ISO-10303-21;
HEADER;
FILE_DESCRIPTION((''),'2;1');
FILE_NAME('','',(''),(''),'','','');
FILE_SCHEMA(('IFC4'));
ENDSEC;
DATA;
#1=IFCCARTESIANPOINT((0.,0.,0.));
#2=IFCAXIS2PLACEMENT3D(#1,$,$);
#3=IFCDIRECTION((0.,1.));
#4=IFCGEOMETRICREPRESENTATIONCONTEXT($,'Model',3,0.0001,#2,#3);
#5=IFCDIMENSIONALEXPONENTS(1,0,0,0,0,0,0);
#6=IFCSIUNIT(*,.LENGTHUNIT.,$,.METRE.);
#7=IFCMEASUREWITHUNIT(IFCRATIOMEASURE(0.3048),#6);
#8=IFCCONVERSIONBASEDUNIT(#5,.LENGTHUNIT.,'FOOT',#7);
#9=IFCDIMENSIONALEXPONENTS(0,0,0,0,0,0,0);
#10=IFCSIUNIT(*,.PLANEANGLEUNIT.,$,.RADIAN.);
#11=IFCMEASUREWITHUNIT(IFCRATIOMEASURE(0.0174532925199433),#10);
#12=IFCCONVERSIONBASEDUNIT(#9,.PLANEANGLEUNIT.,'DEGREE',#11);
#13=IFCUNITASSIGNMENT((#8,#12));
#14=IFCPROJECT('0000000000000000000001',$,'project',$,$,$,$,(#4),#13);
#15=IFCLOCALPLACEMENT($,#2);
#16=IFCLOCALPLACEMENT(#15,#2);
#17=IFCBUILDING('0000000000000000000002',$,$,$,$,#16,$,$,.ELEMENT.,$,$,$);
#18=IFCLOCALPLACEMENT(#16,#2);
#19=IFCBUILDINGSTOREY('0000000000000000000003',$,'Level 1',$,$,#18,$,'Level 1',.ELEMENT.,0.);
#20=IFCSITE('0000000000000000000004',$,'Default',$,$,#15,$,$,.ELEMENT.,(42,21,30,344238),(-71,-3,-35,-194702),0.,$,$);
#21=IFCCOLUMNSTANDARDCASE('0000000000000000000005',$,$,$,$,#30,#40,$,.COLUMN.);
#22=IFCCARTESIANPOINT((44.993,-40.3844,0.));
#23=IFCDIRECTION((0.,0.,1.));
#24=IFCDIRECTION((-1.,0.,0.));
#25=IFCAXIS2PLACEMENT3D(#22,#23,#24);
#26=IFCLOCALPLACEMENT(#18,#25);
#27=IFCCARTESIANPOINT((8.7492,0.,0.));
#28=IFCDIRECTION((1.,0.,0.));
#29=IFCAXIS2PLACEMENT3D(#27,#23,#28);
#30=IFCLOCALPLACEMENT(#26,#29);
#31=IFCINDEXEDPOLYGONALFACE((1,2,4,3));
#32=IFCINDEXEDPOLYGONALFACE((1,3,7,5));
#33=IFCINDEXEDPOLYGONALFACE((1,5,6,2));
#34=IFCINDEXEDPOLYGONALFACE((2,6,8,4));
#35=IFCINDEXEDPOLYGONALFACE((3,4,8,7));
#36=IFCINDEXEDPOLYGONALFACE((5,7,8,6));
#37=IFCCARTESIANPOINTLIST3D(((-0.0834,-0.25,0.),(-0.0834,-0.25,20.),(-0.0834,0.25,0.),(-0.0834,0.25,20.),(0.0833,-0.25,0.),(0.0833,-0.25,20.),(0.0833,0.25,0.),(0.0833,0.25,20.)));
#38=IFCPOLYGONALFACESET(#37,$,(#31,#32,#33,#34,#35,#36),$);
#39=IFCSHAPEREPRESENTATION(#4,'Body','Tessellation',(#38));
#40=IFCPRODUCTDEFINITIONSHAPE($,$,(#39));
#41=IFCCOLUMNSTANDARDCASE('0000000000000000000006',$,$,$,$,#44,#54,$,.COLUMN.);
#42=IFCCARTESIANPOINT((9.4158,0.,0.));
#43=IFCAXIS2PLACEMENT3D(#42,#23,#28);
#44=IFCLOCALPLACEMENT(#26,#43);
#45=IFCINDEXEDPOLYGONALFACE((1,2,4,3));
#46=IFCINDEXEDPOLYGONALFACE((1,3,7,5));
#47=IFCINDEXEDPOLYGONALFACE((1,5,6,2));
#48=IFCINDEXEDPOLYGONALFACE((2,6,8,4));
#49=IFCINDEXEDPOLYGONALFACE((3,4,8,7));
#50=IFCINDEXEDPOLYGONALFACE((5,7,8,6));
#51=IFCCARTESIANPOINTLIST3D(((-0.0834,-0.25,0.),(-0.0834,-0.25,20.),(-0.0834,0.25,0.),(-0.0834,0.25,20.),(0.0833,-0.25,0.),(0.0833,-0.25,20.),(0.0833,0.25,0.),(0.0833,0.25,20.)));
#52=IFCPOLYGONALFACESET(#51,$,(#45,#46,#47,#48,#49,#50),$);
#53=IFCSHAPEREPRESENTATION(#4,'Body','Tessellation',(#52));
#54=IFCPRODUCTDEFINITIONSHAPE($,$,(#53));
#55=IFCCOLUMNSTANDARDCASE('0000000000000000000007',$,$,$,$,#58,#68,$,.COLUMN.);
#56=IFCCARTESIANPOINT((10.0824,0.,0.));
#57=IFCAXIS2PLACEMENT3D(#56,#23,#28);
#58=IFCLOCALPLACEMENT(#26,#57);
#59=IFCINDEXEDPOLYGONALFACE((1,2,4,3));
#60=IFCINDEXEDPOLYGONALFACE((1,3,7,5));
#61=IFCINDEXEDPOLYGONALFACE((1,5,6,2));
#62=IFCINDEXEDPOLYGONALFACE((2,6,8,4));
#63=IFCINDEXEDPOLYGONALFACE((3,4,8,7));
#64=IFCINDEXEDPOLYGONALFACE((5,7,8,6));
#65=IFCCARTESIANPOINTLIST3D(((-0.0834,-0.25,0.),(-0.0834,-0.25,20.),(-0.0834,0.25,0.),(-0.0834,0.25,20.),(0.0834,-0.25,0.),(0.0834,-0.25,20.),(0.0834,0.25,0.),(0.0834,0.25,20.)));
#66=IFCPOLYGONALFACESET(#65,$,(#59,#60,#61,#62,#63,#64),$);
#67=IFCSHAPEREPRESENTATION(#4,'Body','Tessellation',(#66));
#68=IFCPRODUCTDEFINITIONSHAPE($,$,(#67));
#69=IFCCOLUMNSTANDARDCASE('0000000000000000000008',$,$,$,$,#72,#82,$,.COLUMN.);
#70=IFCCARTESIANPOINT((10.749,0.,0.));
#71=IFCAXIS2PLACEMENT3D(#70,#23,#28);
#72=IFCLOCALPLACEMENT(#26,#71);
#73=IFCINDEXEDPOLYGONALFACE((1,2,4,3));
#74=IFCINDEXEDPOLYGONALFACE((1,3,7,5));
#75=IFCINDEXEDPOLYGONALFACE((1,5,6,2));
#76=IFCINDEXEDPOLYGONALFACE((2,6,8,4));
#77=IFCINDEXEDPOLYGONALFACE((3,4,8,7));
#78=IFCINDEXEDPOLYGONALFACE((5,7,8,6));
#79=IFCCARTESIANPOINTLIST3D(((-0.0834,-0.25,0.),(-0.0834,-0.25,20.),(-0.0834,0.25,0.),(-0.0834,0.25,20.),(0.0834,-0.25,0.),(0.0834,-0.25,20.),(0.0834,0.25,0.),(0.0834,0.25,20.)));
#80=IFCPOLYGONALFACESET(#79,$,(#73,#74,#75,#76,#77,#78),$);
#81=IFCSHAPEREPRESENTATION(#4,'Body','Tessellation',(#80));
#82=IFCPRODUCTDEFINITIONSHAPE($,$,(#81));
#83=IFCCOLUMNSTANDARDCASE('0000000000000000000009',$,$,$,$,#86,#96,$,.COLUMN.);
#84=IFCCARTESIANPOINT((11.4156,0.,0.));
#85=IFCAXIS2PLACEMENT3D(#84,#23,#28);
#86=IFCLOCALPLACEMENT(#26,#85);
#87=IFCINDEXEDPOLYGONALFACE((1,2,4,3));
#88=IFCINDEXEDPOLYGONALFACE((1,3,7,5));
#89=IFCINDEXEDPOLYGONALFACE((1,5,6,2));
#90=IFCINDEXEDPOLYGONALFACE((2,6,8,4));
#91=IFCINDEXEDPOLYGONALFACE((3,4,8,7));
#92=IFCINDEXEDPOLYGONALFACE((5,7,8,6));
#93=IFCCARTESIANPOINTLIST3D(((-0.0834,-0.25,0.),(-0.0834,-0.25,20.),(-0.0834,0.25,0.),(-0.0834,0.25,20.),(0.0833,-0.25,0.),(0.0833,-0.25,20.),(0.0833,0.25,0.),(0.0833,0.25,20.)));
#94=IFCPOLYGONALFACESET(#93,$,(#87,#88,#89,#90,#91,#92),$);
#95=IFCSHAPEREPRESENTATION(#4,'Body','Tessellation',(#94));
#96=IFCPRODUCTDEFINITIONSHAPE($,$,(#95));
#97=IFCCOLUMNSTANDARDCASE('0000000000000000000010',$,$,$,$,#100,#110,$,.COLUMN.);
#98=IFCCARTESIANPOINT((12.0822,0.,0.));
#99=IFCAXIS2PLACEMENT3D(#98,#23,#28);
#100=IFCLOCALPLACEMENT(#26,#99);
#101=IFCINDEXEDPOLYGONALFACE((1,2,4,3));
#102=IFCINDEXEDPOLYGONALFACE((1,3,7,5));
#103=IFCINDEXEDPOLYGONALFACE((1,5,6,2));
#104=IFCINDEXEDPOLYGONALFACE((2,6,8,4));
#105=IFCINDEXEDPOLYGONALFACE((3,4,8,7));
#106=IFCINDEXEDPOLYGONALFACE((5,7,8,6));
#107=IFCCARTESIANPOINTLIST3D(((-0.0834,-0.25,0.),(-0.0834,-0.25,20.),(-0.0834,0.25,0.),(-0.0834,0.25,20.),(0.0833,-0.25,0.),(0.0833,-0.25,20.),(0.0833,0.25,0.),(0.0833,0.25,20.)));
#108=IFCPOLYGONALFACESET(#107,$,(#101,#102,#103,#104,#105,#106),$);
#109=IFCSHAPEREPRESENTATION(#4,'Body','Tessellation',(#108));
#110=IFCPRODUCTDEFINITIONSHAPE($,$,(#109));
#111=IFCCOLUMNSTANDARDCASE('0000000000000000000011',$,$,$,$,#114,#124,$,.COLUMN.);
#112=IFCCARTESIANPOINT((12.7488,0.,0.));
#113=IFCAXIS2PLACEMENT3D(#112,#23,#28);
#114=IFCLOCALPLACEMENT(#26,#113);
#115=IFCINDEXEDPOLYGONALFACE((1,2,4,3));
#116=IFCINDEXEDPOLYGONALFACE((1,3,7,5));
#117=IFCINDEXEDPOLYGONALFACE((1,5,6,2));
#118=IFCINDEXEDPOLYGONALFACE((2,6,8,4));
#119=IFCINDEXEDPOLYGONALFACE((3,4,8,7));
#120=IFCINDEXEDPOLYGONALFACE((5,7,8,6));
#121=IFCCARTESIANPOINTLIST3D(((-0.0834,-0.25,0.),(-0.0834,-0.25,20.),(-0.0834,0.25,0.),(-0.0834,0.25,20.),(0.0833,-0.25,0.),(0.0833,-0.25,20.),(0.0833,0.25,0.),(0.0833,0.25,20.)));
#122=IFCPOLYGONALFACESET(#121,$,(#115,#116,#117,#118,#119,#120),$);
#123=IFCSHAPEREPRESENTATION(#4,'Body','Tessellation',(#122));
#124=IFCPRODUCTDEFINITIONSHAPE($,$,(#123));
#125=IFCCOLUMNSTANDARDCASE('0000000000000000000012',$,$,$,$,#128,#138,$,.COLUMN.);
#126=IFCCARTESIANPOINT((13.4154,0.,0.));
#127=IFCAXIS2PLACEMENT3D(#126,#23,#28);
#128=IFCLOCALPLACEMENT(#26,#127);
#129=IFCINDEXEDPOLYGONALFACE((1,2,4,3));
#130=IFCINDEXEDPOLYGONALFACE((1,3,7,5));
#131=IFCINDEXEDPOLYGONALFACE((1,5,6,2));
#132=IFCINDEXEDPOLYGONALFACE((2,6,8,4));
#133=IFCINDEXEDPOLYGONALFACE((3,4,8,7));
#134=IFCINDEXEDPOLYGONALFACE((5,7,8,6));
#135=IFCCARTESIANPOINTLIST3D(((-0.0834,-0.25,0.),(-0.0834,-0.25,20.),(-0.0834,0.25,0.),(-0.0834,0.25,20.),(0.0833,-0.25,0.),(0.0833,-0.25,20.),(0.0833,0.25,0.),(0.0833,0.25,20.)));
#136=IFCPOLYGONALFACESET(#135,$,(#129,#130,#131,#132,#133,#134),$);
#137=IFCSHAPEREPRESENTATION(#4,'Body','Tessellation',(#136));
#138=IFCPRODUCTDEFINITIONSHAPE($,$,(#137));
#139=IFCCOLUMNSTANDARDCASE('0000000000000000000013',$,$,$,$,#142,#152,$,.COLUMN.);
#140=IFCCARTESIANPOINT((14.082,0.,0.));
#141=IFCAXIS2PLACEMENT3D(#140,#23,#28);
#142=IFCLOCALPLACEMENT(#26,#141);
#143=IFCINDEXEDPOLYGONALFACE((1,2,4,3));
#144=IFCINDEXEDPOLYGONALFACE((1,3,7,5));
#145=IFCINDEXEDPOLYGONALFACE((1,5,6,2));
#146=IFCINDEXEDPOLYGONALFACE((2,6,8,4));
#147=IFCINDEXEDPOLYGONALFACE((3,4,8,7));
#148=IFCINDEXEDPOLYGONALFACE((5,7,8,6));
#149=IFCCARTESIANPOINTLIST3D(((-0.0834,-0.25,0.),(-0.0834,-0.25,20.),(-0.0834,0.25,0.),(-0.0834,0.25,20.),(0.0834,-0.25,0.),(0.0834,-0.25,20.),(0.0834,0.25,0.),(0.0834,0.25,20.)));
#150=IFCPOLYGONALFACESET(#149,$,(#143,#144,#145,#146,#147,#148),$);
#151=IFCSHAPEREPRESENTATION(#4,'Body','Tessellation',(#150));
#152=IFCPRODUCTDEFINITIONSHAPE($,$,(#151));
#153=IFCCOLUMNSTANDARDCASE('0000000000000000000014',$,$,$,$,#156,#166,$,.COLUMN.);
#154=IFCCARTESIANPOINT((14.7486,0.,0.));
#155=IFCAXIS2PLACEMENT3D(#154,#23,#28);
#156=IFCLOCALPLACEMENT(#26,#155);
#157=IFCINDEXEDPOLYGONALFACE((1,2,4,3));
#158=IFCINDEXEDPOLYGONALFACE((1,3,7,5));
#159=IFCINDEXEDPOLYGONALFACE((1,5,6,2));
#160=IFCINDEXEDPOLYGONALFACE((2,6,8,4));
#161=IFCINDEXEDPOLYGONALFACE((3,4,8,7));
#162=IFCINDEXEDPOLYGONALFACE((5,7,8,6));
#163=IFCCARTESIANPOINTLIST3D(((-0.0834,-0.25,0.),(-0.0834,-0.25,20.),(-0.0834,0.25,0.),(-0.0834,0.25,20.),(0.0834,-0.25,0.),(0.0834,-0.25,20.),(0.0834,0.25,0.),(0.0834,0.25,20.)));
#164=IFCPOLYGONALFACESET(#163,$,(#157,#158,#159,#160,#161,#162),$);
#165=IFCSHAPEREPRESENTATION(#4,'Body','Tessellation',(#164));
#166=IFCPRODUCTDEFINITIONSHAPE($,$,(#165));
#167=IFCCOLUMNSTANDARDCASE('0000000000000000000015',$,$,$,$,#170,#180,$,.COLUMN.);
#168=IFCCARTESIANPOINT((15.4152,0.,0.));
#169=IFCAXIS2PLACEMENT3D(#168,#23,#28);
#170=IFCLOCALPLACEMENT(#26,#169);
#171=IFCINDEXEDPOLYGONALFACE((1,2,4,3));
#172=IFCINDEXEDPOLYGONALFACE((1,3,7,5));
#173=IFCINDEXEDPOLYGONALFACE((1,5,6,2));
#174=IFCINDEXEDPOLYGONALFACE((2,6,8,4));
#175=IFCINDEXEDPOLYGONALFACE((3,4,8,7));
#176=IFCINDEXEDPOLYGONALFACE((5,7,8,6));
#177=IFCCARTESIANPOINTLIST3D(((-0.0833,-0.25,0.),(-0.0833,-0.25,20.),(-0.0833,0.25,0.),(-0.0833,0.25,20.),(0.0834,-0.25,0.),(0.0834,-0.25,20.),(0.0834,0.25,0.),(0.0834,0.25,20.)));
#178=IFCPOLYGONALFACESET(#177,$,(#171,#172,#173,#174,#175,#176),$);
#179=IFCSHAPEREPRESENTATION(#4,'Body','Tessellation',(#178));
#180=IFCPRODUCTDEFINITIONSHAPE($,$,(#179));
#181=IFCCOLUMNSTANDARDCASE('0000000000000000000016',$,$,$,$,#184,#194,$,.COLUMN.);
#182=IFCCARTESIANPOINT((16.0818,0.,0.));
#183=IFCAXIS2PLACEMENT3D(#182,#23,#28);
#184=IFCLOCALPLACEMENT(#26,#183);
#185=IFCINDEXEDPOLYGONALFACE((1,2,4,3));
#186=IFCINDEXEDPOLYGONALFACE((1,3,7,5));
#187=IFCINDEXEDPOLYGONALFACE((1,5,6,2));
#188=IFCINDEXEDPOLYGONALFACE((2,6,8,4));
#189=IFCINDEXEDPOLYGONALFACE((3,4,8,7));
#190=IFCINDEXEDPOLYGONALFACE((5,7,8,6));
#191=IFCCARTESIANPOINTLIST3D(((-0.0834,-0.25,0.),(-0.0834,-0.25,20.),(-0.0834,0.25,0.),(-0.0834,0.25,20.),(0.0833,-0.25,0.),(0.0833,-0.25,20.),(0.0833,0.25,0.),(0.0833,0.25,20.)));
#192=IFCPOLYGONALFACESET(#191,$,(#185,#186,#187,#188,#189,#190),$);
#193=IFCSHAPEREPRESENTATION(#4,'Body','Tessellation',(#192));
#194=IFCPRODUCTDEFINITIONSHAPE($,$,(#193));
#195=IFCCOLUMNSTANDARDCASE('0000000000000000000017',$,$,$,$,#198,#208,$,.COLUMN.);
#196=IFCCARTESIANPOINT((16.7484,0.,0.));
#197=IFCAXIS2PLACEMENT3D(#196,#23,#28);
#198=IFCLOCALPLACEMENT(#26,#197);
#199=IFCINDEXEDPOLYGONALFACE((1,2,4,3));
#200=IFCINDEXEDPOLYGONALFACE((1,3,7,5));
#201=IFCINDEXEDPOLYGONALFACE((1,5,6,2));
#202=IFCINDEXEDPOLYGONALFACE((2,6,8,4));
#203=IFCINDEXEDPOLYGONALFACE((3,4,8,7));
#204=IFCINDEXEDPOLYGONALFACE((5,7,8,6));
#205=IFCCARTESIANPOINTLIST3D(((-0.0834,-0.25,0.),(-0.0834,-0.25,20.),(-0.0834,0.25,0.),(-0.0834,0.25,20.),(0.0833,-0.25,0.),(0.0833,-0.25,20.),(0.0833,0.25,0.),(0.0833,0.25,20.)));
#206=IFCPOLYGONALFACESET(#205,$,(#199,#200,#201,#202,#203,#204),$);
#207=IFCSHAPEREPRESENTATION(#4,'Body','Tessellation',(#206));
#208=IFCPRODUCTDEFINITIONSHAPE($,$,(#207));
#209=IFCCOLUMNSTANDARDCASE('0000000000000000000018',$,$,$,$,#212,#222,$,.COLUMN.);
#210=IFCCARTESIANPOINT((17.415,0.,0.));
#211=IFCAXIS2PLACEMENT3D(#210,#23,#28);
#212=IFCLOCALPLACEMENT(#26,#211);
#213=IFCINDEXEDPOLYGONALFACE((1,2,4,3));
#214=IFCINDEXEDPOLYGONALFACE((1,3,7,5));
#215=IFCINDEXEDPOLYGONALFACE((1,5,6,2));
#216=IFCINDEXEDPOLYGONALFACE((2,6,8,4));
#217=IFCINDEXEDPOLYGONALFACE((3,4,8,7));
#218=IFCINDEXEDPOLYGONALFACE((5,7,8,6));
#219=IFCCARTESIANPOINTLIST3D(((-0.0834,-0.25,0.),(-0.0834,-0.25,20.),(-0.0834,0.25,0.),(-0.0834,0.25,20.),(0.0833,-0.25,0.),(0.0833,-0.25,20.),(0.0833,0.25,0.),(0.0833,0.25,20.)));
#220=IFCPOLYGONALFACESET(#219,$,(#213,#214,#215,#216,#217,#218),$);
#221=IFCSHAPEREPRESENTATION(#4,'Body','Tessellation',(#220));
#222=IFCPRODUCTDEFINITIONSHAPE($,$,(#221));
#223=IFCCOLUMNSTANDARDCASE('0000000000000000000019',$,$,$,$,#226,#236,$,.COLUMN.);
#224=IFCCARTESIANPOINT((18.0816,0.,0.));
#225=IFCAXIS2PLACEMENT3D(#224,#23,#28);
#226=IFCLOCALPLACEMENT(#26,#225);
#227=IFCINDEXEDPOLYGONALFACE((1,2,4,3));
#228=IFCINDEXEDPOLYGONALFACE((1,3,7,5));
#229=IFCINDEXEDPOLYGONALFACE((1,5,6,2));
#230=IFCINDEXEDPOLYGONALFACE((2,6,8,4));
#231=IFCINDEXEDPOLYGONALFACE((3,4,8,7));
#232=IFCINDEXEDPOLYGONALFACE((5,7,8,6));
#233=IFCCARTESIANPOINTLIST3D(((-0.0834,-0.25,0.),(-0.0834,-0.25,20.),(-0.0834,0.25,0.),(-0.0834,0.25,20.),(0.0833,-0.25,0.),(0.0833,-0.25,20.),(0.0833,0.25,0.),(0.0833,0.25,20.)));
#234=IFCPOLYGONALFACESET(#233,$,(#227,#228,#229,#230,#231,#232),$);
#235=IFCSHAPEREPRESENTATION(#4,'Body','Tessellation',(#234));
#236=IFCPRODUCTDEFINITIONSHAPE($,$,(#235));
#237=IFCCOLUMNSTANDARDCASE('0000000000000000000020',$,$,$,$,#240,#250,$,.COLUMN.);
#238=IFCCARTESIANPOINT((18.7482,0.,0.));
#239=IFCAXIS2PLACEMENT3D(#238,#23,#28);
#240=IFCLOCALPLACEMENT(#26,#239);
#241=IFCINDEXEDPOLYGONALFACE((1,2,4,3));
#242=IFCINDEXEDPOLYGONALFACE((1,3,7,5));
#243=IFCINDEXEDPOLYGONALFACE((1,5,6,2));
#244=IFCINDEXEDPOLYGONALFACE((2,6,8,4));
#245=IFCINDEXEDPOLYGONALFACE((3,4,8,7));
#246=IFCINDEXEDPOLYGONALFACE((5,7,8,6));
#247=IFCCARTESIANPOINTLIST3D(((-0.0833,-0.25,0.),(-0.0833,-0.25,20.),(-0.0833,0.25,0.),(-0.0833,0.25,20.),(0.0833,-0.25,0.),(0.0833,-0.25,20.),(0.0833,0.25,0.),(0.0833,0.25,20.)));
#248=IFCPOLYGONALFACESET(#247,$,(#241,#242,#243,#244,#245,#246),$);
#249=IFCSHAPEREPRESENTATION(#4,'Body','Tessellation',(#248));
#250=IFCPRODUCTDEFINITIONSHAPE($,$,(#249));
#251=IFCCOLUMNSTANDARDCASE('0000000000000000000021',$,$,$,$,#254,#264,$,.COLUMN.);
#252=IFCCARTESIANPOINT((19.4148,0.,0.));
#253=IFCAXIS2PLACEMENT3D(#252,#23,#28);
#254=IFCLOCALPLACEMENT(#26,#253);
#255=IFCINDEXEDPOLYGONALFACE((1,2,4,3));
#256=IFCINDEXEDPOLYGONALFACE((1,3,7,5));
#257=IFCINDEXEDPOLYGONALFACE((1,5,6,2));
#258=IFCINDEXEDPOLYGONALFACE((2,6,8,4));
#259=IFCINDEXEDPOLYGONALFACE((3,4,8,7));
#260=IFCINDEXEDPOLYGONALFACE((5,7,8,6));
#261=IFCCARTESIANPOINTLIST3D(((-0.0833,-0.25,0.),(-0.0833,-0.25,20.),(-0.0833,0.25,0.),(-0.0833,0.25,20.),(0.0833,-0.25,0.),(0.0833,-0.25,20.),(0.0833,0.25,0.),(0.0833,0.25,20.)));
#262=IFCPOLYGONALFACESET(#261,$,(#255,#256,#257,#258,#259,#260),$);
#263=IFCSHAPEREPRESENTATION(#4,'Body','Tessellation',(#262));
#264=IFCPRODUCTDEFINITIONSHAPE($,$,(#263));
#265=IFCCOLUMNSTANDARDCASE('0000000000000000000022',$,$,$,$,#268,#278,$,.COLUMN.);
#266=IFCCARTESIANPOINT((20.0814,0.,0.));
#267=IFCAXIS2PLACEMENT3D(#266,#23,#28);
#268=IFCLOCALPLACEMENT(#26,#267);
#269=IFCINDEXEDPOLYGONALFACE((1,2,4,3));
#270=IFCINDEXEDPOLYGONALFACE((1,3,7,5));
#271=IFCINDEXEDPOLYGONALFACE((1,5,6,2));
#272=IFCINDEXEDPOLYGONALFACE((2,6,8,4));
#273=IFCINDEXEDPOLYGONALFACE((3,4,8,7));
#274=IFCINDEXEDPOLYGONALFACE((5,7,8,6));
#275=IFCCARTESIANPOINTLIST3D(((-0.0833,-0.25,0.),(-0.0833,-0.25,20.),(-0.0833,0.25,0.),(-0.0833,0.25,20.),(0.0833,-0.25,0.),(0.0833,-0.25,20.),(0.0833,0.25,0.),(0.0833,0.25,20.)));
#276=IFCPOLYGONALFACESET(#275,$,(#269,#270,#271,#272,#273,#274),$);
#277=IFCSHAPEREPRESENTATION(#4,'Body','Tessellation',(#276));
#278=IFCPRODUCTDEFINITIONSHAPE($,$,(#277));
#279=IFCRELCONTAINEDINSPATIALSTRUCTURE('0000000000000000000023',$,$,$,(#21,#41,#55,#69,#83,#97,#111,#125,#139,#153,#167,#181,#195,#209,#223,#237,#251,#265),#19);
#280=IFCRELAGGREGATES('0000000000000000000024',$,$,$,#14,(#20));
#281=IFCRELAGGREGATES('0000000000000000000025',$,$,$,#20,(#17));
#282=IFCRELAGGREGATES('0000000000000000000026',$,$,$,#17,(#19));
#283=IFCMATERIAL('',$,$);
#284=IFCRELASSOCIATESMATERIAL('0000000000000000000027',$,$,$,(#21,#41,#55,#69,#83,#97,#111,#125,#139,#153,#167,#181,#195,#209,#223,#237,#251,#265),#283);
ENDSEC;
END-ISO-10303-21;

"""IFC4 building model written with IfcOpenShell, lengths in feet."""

from ifc_helpers import new_model, entity, si_unit, converted_unit, direction, frame, origin, place, context, project, spatial, rectangle, extrude, material, element, save


model = new_model("IFC4")

# Units and contexts
model_context = context("Model", 3, precision=0.0001, world=origin(), true_north=direction((0.0, 1.0)))
ifc_project = project(units=[converted_unit("LENGTHUNIT", "FOOT", entity("IfcRatioMeasure", 0.3048), si_unit("LENGTHUNIT", "METRE"), dimensions=[1, 0, 0, 0, 0, 0, 0]), converted_unit("PLANEANGLEUNIT", "DEGREE", entity("IfcRatioMeasure", 0.0174532925199433), si_unit("PLANEANGLEUNIT", "RADIAN"), dimensions=[0, 0, 0, 0, 0, 0, 0])], contexts=[model_context])

# Site, building, storey
site_placement = place(None, origin())
site = spatial("IfcSite", under=ifc_project, at=site_placement, Name="Default", CompositionType="ELEMENT", RefLatitude=(42, 21, 30, 344238), RefLongitude=(-71, -3, -35, -194702), RefElevation=0.0)
building_placement = place(site_placement, origin())
building = spatial("IfcBuilding", under=site, at=building_placement, CompositionType="ELEMENT")
storey_placement = place(building_placement, origin())
storey = spatial("IfcBuildingStorey", under=building, at=storey_placement, Name="Level 1", LongName="Level 1", CompositionType="ELEMENT", Elevation=0.0)

# Columns
ifc_material = material(Name="")
placement = place(storey_placement, frame((44.993, -40.3844, 0.0), z_axis=(0.0, 0.0, 1.0), x_axis=(-1.0, 0.0, 0.0)))
for number, where, z_axis, x_axis in (
    (1, (8.7492, 0.0, 0.0), (0.0, 0.0, 1.0), (1.0, 0.0, 0.0)),
    (2, (9.4158, 0.0, 0.0), (0.0, 0.0, 1.0), (1.0, 0.0, 0.0)),
    (3, (10.0824, 0.0, 0.0), (0.0, 0.0, 1.0), (1.0, 0.0, 0.0)),
    (4, (10.749, 0.0, 0.0), (0.0, 0.0, 1.0), (1.0, 0.0, 0.0)),
    (5, (11.4156, 0.0, 0.0), (0.0, 0.0, 1.0), (1.0, 0.0, 0.0)),
    (6, (12.0822, 0.0, 0.0), (0.0, 0.0, 1.0), (1.0, 0.0, 0.0)),
    (7, (12.7488, 0.0, 0.0), (0.0, 0.0, 1.0), (1.0, 0.0, 0.0)),
    (8, (13.4154, 0.0, 0.0), (0.0, 0.0, 1.0), (1.0, 0.0, 0.0)),
    (9, (14.082, 0.0, 0.0), (0.0, 0.0, 1.0), (1.0, 0.0, 0.0)),
    (10, (14.7486, 0.0, 0.0), (0.0, 0.0, 1.0), (1.0, 0.0, 0.0)),
    (11, (15.4152, 0.0, 0.0), (0.0, 0.0, 1.0), (1.0, 0.0, 0.0)),
    (12, (16.0818, 0.0, 0.0), (0.0, 0.0, 1.0), (1.0, 0.0, 0.0)),
    (13, (16.7484, 0.0, 0.0), (0.0, 0.0, 1.0), (1.0, 0.0, 0.0)),
    (14, (17.415, 0.0, 0.0), (0.0, 0.0, 1.0), (1.0, 0.0, 0.0)),
    (15, (18.0816, 0.0, 0.0), (0.0, 0.0, 1.0), (1.0, 0.0, 0.0)),
    (16, (18.7482, 0.0, 0.0), (0.0, 0.0, 1.0), (1.0, 0.0, 0.0)),
    (17, (19.4148, 0.0, 0.0), (0.0, 0.0, 1.0), (1.0, 0.0, 0.0)),
    (18, (20.0814, 0.0, 0.0), (0.0, 0.0, 1.0), (1.0, 0.0, 0.0)),
):
    element("IfcColumnStandardCase", number, at=place(placement, frame(where, z_axis=z_axis, x_axis=x_axis)), inside=storey, material=ifc_material, PredefinedType="COLUMN", context=model_context, shape_type="SweptSolid", body=[
        extrude(rectangle(XDim=0.1667, YDim=0.5), origin(), (0.0, 0.0, 1.0), 20.0),
    ])

save(model, "model.ifc")
